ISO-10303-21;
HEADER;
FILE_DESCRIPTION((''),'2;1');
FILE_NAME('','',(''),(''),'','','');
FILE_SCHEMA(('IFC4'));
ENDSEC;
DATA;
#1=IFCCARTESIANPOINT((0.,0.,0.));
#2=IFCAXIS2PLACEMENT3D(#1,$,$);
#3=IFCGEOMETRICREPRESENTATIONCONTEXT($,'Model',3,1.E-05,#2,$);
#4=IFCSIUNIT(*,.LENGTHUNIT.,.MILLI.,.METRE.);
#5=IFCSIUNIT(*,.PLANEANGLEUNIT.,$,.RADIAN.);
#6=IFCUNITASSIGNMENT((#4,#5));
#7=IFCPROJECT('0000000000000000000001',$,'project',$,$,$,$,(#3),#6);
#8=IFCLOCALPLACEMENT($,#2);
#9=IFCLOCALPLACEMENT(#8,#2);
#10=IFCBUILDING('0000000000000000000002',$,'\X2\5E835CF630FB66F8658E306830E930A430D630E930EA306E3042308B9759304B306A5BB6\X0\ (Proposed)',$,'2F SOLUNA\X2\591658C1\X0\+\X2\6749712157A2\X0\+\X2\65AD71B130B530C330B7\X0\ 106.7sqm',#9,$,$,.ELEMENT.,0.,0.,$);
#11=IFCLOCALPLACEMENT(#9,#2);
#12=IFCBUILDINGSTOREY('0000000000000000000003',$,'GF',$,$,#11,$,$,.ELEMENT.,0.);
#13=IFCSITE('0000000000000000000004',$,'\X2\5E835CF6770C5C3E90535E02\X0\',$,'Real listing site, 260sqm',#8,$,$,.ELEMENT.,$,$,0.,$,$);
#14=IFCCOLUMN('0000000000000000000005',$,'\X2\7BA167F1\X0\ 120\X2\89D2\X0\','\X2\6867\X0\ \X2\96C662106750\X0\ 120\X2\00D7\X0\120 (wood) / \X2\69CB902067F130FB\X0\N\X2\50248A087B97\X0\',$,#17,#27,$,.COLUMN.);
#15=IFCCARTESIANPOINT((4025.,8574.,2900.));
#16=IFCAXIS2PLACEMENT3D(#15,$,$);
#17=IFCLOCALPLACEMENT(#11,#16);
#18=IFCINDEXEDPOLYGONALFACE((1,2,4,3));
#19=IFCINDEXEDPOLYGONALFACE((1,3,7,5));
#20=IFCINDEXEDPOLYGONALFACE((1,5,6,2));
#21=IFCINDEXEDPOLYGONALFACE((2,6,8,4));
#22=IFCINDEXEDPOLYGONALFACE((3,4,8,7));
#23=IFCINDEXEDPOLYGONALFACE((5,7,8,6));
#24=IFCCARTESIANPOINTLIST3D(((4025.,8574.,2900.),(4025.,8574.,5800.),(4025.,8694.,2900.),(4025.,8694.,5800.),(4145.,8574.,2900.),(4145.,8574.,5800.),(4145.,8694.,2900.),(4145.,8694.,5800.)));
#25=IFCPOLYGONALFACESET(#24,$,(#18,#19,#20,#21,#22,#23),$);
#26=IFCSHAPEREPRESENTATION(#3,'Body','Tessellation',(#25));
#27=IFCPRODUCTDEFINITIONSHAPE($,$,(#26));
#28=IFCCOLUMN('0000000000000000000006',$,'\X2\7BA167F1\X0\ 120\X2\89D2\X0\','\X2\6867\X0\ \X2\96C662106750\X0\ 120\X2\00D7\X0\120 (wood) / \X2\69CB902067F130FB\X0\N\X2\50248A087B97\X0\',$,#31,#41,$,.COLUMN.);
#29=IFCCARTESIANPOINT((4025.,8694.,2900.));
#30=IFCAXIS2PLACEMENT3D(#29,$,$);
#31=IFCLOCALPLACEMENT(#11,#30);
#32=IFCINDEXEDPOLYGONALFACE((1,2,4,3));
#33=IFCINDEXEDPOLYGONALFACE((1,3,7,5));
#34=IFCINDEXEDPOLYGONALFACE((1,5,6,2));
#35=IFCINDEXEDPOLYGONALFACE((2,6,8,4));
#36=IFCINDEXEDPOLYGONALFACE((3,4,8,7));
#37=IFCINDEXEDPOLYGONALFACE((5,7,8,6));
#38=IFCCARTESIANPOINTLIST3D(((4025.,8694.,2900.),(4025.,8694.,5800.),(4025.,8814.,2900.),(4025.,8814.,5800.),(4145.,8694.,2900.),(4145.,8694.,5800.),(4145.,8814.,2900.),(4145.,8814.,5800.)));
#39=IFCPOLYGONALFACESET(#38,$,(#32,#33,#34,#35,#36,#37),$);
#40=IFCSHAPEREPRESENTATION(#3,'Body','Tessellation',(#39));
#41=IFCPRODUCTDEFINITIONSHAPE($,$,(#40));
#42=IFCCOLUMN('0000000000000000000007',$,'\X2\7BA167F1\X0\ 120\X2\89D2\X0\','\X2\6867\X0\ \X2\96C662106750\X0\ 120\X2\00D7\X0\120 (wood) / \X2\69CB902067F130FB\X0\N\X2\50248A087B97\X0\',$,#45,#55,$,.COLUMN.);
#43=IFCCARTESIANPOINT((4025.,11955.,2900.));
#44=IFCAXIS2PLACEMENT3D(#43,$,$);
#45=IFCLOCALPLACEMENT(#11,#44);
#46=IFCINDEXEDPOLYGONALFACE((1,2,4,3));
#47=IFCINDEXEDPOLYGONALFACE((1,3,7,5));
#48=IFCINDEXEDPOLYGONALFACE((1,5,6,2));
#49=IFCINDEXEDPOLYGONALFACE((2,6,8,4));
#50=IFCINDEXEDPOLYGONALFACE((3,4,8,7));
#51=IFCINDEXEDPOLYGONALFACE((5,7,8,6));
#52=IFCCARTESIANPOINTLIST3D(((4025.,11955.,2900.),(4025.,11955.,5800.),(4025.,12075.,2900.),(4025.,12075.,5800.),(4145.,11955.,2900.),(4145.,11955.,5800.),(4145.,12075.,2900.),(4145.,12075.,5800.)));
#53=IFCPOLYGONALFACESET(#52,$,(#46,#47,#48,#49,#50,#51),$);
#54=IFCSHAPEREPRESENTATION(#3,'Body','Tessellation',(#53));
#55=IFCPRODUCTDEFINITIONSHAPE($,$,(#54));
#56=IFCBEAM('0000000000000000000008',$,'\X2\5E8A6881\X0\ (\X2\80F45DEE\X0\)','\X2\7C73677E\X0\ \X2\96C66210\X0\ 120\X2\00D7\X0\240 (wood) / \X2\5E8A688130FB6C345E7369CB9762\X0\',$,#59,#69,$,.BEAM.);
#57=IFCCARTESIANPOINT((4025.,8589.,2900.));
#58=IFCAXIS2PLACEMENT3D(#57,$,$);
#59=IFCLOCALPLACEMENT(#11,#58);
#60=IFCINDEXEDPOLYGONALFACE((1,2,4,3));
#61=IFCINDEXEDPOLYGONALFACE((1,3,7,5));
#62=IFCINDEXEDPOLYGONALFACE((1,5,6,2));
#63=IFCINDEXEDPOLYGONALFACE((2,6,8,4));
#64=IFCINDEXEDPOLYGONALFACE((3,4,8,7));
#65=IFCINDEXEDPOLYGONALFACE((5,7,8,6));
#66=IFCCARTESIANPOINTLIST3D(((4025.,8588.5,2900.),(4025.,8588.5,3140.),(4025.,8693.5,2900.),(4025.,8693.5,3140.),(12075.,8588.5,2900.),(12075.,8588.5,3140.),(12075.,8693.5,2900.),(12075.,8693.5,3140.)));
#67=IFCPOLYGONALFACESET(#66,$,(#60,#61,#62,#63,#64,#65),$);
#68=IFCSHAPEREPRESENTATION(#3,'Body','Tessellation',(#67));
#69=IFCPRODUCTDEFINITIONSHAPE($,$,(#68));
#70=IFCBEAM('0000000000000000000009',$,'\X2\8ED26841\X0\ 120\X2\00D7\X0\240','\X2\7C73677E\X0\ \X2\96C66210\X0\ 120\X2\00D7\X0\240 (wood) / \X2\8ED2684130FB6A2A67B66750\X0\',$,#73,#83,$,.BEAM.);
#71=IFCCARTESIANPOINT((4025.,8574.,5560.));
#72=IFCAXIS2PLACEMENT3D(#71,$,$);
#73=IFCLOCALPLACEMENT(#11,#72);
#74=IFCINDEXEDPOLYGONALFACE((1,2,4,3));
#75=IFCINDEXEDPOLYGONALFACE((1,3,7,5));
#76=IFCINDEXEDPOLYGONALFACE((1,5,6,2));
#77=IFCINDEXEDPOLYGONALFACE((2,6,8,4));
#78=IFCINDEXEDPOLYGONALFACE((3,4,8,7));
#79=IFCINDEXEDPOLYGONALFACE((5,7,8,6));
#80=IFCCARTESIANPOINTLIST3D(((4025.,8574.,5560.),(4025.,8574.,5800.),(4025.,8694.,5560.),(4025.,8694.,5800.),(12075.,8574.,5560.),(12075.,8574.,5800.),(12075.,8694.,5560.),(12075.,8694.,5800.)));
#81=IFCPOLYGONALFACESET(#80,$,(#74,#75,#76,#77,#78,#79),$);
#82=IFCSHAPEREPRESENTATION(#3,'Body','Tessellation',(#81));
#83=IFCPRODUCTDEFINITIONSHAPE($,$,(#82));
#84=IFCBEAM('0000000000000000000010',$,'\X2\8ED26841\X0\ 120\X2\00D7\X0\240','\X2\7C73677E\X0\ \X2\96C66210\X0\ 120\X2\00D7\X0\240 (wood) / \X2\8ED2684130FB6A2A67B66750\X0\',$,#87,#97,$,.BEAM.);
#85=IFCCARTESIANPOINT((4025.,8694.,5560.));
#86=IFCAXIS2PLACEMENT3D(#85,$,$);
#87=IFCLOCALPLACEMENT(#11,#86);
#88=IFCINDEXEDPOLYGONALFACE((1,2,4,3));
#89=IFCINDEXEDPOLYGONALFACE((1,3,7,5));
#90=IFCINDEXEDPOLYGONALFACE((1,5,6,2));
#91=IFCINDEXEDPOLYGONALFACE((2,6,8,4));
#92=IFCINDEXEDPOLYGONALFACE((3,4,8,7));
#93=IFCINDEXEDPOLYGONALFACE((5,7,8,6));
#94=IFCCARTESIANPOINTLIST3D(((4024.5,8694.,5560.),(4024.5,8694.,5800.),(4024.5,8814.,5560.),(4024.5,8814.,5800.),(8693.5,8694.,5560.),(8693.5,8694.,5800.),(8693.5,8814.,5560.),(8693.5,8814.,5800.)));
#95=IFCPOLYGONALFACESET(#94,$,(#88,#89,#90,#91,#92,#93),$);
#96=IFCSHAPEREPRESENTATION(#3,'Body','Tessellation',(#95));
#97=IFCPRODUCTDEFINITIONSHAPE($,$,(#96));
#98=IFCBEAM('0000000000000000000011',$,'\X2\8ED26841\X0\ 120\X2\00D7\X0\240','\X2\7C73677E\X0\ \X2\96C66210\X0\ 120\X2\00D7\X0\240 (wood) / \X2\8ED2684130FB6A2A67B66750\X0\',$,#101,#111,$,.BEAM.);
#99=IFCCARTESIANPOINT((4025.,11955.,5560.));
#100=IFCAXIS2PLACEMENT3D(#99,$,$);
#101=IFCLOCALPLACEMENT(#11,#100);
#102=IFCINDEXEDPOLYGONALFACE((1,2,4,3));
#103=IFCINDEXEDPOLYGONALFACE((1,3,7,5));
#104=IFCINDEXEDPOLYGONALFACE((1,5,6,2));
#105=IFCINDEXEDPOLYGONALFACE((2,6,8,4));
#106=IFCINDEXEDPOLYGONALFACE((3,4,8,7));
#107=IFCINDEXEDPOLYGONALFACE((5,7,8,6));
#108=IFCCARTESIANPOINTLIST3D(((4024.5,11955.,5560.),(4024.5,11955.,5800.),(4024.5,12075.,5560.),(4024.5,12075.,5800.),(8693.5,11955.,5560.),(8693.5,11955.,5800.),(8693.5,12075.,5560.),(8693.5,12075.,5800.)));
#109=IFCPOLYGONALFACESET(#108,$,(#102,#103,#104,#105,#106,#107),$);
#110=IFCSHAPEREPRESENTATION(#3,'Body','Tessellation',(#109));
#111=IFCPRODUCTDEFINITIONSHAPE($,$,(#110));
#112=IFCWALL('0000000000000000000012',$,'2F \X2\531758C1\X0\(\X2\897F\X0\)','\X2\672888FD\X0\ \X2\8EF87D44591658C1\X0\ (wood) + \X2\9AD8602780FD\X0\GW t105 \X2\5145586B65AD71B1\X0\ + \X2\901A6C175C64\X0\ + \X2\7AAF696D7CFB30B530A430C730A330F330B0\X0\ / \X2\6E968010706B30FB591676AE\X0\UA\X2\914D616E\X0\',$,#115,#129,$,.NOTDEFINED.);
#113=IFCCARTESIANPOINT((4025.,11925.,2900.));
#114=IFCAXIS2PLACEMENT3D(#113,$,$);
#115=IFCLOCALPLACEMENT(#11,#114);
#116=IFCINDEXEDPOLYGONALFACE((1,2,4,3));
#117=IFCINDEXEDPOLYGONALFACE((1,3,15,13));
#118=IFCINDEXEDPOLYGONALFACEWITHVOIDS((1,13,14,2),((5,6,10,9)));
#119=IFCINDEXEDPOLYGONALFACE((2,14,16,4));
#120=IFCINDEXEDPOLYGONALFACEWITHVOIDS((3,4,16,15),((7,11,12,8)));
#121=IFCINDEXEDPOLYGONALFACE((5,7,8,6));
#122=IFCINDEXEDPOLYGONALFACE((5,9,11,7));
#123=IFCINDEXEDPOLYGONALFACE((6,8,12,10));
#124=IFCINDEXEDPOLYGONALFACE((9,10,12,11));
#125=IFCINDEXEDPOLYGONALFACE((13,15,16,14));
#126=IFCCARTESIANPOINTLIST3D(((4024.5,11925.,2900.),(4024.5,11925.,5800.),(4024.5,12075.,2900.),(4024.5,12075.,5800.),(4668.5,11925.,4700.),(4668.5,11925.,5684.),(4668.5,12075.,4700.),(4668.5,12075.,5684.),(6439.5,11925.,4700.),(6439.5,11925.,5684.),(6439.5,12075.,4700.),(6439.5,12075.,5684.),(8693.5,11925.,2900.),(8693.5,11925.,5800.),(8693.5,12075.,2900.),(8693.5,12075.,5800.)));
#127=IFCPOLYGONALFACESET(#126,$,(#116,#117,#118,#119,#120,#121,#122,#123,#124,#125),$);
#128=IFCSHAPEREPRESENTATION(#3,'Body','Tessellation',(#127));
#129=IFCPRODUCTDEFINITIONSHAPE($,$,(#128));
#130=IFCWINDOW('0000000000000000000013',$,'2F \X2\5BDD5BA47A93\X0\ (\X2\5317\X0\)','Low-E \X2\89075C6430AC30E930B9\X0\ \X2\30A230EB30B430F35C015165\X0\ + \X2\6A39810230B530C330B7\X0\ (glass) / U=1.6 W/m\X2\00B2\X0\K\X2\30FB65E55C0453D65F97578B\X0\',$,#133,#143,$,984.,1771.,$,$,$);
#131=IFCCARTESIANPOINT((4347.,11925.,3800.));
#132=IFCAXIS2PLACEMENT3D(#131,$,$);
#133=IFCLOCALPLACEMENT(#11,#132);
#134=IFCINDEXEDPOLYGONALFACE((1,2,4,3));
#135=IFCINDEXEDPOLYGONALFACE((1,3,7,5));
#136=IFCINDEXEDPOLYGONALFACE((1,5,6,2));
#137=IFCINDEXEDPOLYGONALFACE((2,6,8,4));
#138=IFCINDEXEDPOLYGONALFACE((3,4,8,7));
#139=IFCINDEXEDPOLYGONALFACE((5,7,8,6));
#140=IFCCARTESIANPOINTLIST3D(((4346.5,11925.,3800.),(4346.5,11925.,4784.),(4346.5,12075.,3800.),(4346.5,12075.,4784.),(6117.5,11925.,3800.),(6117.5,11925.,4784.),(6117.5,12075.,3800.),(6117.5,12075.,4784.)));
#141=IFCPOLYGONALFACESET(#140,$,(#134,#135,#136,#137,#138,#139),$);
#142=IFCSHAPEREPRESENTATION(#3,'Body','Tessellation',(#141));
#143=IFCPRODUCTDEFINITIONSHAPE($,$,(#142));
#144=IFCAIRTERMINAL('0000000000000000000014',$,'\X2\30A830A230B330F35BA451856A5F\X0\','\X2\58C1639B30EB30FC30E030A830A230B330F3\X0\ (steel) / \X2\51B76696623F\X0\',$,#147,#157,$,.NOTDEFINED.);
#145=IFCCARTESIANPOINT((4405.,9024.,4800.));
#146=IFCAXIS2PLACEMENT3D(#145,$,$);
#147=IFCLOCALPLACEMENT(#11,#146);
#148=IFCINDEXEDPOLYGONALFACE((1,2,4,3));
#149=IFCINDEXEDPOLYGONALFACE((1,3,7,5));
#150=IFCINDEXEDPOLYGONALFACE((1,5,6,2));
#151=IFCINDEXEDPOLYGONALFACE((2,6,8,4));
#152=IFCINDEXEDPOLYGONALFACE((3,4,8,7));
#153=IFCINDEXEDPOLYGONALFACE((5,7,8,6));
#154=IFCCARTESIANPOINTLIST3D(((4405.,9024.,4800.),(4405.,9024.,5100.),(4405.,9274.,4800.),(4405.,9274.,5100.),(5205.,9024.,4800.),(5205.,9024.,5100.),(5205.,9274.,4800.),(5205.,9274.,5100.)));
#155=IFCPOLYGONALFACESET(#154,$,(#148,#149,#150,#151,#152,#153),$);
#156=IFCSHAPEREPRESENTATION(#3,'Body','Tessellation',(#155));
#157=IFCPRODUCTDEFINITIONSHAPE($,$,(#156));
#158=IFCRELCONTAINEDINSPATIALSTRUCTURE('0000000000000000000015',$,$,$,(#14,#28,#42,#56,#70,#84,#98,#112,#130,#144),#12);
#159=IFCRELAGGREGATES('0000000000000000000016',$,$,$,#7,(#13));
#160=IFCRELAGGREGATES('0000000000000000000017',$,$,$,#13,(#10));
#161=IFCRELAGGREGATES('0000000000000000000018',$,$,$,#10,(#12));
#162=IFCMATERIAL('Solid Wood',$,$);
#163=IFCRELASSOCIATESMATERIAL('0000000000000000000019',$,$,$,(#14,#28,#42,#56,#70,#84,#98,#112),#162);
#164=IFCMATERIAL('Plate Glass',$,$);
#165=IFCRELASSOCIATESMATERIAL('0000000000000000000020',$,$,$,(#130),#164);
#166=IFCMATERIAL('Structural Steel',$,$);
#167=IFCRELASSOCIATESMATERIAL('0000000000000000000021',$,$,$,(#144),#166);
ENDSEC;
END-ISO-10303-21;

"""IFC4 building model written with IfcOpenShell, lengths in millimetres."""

from ifc_helpers import new_model, si_unit, frame, frame_2d, origin, place, context, project, spatial, rectangle, extrude, material, element, fill, save


model = new_model("IFC4")

# Units and contexts
model_context = context("Model", 3, precision=1e-05, world=origin())
ifc_project = project(units=[si_unit("LENGTHUNIT", "METRE", prefix="MILLI"), si_unit("PLANEANGLEUNIT", "RADIAN")], contexts=[model_context])

# Site, building, storey
site_placement = place(None, origin())
site = spatial("IfcSite", under=ifc_project, at=site_placement, Name="広島県尾道市", ObjectType="Real listing site, 260sqm", CompositionType="ELEMENT", RefElevation=0.0)
building_placement = place(site_placement, origin())
building = spatial("IfcBuilding", under=site, at=building_placement, Name="広島・書斎とライブラリのある静かな家 (Proposed)", ObjectType="2F SOLUNA外壁+杉無垢+断熱サッシ 106.7sqm", CompositionType="ELEMENT", ElevationOfRefHeight=0.0, ElevationOfTerrain=0.0)
storey_placement = place(building_placement, origin())
storey = spatial("IfcBuildingStorey", under=building, at=storey_placement, Name="GF", CompositionType="ELEMENT", Elevation=0.0)

# Columns
ifc_material_1 = material(Name="Solid Wood")
column_1_placement = place(storey_placement, frame((4025.0, 8574.0, 2900.0)))
element("IfcColumn", 1, at=column_1_placement, inside=storey, material=ifc_material_1, Name="管柱 120角", Description="桧 集成材 120×120 (wood) / 構造柱・N値計算", PredefinedType="COLUMN", context=model_context, shape_type="SweptSolid", body=[
    extrude(rectangle(XDim=120.0, YDim=120.0, at=frame_2d((60.0, 60.0))), frame((4025.0, 8574.0, 2900.0)), (0.0, 0.0, 1.0), 2900.0),
])
column_2_placement = place(storey_placement, frame((4025.0, 8694.0, 2900.0)))
element("IfcColumn", 2, at=column_2_placement, inside=storey, material=ifc_material_1, Name="管柱 120角", Description="桧 集成材 120×120 (wood) / 構造柱・N値計算", PredefinedType="COLUMN", context=model_context, shape_type="SweptSolid", body=[
    extrude(rectangle(XDim=120.0, YDim=120.0, at=frame_2d((60.0, 60.0))), frame((4025.0, 8694.0, 2900.0)), (0.0, 0.0, 1.0), 2900.0),
])
column_3_placement = place(storey_placement, frame((4025.0, 11955.0, 2900.0)))
element("IfcColumn", 3, at=column_3_placement, inside=storey, material=ifc_material_1, Name="管柱 120角", Description="桧 集成材 120×120 (wood) / 構造柱・N値計算", PredefinedType="COLUMN", context=model_context, shape_type="SweptSolid", body=[
    extrude(rectangle(XDim=120.0, YDim=120.0, at=frame_2d((60.0, 60.0))), frame((4025.0, 11955.0, 2900.0)), (0.0, 0.0, 1.0), 2900.0),
])

# Beams
beam_1_placement = place(storey_placement, frame((4025.0, 8589.0, 2900.0)))
element("IfcBeam", 4, at=beam_1_placement, inside=storey, material=ifc_material_1, Name="床梁 (胴差)", Description="米松 集成 120×240 (wood) / 床梁・水平構面", PredefinedType="BEAM", context=model_context, shape_type="SweptSolid", body=[
    extrude(rectangle(XDim=8050.0, YDim=105.0, at=frame_2d((4025.0, 52.0))), frame((4025.0, 8589.0, 2900.0)), (0.0, 0.0, 1.0), 240.0),
])
beam_2_placement = place(storey_placement, frame((4025.0, 8574.0, 5560.0)))
element("IfcBeam", 5, at=beam_2_placement, inside=storey, material=ifc_material_1, Name="軒桁 120×240", Description="米松 集成 120×240 (wood) / 軒桁・横架材", PredefinedType="BEAM", context=model_context, shape_type="SweptSolid", body=[
    extrude(rectangle(XDim=8050.0, YDim=120.0, at=frame_2d((4025.0, 60.0))), frame((4025.0, 8574.0, 5560.0)), (0.0, 0.0, 1.0), 240.0),
])
beam_3_placement = place(storey_placement, frame((4025.0, 8694.0, 5560.0)))
element("IfcBeam", 6, at=beam_3_placement, inside=storey, material=ifc_material_1, Name="軒桁 120×240", Description="米松 集成 120×240 (wood) / 軒桁・横架材", PredefinedType="BEAM", context=model_context, shape_type="SweptSolid", body=[
    extrude(rectangle(XDim=4669.0, YDim=120.0, at=frame_2d((2334.0, 60.0))), frame((4025.0, 8694.0, 5560.0)), (0.0, 0.0, 1.0), 240.0),
])
beam_4_placement = place(storey_placement, frame((4025.0, 11955.0, 5560.0)))
element("IfcBeam", 7, at=beam_4_placement, inside=storey, material=ifc_material_1, Name="軒桁 120×240", Description="米松 集成 120×240 (wood) / 軒桁・横架材", PredefinedType="BEAM", context=model_context, shape_type="SweptSolid", body=[
    extrude(rectangle(XDim=4669.0, YDim=120.0, at=frame_2d((2334.0, 60.0))), frame((4025.0, 11955.0, 5560.0)), (0.0, 0.0, 1.0), 240.0),
])

# Wall, opening, window
wall_1_placement = place(storey_placement, frame((4025.0, 11925.0, 2900.0)))
wall_1 = element("IfcWall", 8, at=wall_1_placement, inside=storey, material=ifc_material_1, Name="2F 北壁(西)", Description="木製 軸組外壁 (wood) + 高性能GW t105 充填断熱 + 通気層 + 窯業系サイディング / 準耐火・外皮UA配慮", PredefinedType="NOTDEFINED", context=model_context, shape_type="SweptSolid", body=[
    extrude(rectangle(XDim=4669.0, YDim=150.0, at=frame_2d((2334.0, 75.0))), frame((4025.0, 11925.0, 2900.0)), (0.0, 0.0, 1.0), 2900.0),
])
opening_placement = place(storey_placement, frame((4347.0, 11925.0, 3800.0)))
opening = element("IfcOpeningElement", 9, at=opening_placement, cuts=wall_1, PredefinedType="NOTDEFINED", context=model_context, shape_type="SweptSolid", body=[
    extrude(rectangle(XDim=1771.0, YDim=150.0, at=frame_2d((885.0, 75.0))), frame((4347.0, 11925.0, 3800.0)), (0.0, 0.0, 1.0), 984.0),
])
ifc_material_2 = material(Name="Plate Glass")
window_placement = place(storey_placement, frame((4347.0, 11925.0, 3800.0)))
window = element("IfcWindow", 10, at=window_placement, inside=storey, material=ifc_material_2, Name="2F 寝室窓 (北)", Description="Low-E 複層ガラス アルゴン封入 + 樹脂サッシ (glass) / U=1.6 W/m²K・日射取得型", OverallHeight=984.0, OverallWidth=1771.0, context=model_context, shape_type="SweptSolid", body=[
    extrude(rectangle(XDim=1771.0, YDim=150.0, at=frame_2d((885.0, 75.0))), frame((4347.0, 11925.0, 3800.0)), (0.0, 0.0, 1.0), 984.0),
])
fill(opening, window)

# Shared definitions
ifc_material_3 = material(Name="Structural Steel")

# Air terminal
air_terminal_placement = place(storey_placement, frame((4405.0, 9024.0, 4800.0)))
element("IfcAirTerminal", 11, at=air_terminal_placement, inside=storey, material=ifc_material_3, Name="エアコン室内機", Description="壁掛ルームエアコン (steel) / 冷暖房", PredefinedType="NOTDEFINED", context=model_context, shape_type="SweptSolid", body=[
    extrude(rectangle(XDim=800.0, YDim=250.0, at=frame_2d((400.0, 125.0))), frame((4405.0, 9024.0, 4800.0)), (0.0, 0.0, 1.0), 300.0),
])

save(model, "model.ifc")
